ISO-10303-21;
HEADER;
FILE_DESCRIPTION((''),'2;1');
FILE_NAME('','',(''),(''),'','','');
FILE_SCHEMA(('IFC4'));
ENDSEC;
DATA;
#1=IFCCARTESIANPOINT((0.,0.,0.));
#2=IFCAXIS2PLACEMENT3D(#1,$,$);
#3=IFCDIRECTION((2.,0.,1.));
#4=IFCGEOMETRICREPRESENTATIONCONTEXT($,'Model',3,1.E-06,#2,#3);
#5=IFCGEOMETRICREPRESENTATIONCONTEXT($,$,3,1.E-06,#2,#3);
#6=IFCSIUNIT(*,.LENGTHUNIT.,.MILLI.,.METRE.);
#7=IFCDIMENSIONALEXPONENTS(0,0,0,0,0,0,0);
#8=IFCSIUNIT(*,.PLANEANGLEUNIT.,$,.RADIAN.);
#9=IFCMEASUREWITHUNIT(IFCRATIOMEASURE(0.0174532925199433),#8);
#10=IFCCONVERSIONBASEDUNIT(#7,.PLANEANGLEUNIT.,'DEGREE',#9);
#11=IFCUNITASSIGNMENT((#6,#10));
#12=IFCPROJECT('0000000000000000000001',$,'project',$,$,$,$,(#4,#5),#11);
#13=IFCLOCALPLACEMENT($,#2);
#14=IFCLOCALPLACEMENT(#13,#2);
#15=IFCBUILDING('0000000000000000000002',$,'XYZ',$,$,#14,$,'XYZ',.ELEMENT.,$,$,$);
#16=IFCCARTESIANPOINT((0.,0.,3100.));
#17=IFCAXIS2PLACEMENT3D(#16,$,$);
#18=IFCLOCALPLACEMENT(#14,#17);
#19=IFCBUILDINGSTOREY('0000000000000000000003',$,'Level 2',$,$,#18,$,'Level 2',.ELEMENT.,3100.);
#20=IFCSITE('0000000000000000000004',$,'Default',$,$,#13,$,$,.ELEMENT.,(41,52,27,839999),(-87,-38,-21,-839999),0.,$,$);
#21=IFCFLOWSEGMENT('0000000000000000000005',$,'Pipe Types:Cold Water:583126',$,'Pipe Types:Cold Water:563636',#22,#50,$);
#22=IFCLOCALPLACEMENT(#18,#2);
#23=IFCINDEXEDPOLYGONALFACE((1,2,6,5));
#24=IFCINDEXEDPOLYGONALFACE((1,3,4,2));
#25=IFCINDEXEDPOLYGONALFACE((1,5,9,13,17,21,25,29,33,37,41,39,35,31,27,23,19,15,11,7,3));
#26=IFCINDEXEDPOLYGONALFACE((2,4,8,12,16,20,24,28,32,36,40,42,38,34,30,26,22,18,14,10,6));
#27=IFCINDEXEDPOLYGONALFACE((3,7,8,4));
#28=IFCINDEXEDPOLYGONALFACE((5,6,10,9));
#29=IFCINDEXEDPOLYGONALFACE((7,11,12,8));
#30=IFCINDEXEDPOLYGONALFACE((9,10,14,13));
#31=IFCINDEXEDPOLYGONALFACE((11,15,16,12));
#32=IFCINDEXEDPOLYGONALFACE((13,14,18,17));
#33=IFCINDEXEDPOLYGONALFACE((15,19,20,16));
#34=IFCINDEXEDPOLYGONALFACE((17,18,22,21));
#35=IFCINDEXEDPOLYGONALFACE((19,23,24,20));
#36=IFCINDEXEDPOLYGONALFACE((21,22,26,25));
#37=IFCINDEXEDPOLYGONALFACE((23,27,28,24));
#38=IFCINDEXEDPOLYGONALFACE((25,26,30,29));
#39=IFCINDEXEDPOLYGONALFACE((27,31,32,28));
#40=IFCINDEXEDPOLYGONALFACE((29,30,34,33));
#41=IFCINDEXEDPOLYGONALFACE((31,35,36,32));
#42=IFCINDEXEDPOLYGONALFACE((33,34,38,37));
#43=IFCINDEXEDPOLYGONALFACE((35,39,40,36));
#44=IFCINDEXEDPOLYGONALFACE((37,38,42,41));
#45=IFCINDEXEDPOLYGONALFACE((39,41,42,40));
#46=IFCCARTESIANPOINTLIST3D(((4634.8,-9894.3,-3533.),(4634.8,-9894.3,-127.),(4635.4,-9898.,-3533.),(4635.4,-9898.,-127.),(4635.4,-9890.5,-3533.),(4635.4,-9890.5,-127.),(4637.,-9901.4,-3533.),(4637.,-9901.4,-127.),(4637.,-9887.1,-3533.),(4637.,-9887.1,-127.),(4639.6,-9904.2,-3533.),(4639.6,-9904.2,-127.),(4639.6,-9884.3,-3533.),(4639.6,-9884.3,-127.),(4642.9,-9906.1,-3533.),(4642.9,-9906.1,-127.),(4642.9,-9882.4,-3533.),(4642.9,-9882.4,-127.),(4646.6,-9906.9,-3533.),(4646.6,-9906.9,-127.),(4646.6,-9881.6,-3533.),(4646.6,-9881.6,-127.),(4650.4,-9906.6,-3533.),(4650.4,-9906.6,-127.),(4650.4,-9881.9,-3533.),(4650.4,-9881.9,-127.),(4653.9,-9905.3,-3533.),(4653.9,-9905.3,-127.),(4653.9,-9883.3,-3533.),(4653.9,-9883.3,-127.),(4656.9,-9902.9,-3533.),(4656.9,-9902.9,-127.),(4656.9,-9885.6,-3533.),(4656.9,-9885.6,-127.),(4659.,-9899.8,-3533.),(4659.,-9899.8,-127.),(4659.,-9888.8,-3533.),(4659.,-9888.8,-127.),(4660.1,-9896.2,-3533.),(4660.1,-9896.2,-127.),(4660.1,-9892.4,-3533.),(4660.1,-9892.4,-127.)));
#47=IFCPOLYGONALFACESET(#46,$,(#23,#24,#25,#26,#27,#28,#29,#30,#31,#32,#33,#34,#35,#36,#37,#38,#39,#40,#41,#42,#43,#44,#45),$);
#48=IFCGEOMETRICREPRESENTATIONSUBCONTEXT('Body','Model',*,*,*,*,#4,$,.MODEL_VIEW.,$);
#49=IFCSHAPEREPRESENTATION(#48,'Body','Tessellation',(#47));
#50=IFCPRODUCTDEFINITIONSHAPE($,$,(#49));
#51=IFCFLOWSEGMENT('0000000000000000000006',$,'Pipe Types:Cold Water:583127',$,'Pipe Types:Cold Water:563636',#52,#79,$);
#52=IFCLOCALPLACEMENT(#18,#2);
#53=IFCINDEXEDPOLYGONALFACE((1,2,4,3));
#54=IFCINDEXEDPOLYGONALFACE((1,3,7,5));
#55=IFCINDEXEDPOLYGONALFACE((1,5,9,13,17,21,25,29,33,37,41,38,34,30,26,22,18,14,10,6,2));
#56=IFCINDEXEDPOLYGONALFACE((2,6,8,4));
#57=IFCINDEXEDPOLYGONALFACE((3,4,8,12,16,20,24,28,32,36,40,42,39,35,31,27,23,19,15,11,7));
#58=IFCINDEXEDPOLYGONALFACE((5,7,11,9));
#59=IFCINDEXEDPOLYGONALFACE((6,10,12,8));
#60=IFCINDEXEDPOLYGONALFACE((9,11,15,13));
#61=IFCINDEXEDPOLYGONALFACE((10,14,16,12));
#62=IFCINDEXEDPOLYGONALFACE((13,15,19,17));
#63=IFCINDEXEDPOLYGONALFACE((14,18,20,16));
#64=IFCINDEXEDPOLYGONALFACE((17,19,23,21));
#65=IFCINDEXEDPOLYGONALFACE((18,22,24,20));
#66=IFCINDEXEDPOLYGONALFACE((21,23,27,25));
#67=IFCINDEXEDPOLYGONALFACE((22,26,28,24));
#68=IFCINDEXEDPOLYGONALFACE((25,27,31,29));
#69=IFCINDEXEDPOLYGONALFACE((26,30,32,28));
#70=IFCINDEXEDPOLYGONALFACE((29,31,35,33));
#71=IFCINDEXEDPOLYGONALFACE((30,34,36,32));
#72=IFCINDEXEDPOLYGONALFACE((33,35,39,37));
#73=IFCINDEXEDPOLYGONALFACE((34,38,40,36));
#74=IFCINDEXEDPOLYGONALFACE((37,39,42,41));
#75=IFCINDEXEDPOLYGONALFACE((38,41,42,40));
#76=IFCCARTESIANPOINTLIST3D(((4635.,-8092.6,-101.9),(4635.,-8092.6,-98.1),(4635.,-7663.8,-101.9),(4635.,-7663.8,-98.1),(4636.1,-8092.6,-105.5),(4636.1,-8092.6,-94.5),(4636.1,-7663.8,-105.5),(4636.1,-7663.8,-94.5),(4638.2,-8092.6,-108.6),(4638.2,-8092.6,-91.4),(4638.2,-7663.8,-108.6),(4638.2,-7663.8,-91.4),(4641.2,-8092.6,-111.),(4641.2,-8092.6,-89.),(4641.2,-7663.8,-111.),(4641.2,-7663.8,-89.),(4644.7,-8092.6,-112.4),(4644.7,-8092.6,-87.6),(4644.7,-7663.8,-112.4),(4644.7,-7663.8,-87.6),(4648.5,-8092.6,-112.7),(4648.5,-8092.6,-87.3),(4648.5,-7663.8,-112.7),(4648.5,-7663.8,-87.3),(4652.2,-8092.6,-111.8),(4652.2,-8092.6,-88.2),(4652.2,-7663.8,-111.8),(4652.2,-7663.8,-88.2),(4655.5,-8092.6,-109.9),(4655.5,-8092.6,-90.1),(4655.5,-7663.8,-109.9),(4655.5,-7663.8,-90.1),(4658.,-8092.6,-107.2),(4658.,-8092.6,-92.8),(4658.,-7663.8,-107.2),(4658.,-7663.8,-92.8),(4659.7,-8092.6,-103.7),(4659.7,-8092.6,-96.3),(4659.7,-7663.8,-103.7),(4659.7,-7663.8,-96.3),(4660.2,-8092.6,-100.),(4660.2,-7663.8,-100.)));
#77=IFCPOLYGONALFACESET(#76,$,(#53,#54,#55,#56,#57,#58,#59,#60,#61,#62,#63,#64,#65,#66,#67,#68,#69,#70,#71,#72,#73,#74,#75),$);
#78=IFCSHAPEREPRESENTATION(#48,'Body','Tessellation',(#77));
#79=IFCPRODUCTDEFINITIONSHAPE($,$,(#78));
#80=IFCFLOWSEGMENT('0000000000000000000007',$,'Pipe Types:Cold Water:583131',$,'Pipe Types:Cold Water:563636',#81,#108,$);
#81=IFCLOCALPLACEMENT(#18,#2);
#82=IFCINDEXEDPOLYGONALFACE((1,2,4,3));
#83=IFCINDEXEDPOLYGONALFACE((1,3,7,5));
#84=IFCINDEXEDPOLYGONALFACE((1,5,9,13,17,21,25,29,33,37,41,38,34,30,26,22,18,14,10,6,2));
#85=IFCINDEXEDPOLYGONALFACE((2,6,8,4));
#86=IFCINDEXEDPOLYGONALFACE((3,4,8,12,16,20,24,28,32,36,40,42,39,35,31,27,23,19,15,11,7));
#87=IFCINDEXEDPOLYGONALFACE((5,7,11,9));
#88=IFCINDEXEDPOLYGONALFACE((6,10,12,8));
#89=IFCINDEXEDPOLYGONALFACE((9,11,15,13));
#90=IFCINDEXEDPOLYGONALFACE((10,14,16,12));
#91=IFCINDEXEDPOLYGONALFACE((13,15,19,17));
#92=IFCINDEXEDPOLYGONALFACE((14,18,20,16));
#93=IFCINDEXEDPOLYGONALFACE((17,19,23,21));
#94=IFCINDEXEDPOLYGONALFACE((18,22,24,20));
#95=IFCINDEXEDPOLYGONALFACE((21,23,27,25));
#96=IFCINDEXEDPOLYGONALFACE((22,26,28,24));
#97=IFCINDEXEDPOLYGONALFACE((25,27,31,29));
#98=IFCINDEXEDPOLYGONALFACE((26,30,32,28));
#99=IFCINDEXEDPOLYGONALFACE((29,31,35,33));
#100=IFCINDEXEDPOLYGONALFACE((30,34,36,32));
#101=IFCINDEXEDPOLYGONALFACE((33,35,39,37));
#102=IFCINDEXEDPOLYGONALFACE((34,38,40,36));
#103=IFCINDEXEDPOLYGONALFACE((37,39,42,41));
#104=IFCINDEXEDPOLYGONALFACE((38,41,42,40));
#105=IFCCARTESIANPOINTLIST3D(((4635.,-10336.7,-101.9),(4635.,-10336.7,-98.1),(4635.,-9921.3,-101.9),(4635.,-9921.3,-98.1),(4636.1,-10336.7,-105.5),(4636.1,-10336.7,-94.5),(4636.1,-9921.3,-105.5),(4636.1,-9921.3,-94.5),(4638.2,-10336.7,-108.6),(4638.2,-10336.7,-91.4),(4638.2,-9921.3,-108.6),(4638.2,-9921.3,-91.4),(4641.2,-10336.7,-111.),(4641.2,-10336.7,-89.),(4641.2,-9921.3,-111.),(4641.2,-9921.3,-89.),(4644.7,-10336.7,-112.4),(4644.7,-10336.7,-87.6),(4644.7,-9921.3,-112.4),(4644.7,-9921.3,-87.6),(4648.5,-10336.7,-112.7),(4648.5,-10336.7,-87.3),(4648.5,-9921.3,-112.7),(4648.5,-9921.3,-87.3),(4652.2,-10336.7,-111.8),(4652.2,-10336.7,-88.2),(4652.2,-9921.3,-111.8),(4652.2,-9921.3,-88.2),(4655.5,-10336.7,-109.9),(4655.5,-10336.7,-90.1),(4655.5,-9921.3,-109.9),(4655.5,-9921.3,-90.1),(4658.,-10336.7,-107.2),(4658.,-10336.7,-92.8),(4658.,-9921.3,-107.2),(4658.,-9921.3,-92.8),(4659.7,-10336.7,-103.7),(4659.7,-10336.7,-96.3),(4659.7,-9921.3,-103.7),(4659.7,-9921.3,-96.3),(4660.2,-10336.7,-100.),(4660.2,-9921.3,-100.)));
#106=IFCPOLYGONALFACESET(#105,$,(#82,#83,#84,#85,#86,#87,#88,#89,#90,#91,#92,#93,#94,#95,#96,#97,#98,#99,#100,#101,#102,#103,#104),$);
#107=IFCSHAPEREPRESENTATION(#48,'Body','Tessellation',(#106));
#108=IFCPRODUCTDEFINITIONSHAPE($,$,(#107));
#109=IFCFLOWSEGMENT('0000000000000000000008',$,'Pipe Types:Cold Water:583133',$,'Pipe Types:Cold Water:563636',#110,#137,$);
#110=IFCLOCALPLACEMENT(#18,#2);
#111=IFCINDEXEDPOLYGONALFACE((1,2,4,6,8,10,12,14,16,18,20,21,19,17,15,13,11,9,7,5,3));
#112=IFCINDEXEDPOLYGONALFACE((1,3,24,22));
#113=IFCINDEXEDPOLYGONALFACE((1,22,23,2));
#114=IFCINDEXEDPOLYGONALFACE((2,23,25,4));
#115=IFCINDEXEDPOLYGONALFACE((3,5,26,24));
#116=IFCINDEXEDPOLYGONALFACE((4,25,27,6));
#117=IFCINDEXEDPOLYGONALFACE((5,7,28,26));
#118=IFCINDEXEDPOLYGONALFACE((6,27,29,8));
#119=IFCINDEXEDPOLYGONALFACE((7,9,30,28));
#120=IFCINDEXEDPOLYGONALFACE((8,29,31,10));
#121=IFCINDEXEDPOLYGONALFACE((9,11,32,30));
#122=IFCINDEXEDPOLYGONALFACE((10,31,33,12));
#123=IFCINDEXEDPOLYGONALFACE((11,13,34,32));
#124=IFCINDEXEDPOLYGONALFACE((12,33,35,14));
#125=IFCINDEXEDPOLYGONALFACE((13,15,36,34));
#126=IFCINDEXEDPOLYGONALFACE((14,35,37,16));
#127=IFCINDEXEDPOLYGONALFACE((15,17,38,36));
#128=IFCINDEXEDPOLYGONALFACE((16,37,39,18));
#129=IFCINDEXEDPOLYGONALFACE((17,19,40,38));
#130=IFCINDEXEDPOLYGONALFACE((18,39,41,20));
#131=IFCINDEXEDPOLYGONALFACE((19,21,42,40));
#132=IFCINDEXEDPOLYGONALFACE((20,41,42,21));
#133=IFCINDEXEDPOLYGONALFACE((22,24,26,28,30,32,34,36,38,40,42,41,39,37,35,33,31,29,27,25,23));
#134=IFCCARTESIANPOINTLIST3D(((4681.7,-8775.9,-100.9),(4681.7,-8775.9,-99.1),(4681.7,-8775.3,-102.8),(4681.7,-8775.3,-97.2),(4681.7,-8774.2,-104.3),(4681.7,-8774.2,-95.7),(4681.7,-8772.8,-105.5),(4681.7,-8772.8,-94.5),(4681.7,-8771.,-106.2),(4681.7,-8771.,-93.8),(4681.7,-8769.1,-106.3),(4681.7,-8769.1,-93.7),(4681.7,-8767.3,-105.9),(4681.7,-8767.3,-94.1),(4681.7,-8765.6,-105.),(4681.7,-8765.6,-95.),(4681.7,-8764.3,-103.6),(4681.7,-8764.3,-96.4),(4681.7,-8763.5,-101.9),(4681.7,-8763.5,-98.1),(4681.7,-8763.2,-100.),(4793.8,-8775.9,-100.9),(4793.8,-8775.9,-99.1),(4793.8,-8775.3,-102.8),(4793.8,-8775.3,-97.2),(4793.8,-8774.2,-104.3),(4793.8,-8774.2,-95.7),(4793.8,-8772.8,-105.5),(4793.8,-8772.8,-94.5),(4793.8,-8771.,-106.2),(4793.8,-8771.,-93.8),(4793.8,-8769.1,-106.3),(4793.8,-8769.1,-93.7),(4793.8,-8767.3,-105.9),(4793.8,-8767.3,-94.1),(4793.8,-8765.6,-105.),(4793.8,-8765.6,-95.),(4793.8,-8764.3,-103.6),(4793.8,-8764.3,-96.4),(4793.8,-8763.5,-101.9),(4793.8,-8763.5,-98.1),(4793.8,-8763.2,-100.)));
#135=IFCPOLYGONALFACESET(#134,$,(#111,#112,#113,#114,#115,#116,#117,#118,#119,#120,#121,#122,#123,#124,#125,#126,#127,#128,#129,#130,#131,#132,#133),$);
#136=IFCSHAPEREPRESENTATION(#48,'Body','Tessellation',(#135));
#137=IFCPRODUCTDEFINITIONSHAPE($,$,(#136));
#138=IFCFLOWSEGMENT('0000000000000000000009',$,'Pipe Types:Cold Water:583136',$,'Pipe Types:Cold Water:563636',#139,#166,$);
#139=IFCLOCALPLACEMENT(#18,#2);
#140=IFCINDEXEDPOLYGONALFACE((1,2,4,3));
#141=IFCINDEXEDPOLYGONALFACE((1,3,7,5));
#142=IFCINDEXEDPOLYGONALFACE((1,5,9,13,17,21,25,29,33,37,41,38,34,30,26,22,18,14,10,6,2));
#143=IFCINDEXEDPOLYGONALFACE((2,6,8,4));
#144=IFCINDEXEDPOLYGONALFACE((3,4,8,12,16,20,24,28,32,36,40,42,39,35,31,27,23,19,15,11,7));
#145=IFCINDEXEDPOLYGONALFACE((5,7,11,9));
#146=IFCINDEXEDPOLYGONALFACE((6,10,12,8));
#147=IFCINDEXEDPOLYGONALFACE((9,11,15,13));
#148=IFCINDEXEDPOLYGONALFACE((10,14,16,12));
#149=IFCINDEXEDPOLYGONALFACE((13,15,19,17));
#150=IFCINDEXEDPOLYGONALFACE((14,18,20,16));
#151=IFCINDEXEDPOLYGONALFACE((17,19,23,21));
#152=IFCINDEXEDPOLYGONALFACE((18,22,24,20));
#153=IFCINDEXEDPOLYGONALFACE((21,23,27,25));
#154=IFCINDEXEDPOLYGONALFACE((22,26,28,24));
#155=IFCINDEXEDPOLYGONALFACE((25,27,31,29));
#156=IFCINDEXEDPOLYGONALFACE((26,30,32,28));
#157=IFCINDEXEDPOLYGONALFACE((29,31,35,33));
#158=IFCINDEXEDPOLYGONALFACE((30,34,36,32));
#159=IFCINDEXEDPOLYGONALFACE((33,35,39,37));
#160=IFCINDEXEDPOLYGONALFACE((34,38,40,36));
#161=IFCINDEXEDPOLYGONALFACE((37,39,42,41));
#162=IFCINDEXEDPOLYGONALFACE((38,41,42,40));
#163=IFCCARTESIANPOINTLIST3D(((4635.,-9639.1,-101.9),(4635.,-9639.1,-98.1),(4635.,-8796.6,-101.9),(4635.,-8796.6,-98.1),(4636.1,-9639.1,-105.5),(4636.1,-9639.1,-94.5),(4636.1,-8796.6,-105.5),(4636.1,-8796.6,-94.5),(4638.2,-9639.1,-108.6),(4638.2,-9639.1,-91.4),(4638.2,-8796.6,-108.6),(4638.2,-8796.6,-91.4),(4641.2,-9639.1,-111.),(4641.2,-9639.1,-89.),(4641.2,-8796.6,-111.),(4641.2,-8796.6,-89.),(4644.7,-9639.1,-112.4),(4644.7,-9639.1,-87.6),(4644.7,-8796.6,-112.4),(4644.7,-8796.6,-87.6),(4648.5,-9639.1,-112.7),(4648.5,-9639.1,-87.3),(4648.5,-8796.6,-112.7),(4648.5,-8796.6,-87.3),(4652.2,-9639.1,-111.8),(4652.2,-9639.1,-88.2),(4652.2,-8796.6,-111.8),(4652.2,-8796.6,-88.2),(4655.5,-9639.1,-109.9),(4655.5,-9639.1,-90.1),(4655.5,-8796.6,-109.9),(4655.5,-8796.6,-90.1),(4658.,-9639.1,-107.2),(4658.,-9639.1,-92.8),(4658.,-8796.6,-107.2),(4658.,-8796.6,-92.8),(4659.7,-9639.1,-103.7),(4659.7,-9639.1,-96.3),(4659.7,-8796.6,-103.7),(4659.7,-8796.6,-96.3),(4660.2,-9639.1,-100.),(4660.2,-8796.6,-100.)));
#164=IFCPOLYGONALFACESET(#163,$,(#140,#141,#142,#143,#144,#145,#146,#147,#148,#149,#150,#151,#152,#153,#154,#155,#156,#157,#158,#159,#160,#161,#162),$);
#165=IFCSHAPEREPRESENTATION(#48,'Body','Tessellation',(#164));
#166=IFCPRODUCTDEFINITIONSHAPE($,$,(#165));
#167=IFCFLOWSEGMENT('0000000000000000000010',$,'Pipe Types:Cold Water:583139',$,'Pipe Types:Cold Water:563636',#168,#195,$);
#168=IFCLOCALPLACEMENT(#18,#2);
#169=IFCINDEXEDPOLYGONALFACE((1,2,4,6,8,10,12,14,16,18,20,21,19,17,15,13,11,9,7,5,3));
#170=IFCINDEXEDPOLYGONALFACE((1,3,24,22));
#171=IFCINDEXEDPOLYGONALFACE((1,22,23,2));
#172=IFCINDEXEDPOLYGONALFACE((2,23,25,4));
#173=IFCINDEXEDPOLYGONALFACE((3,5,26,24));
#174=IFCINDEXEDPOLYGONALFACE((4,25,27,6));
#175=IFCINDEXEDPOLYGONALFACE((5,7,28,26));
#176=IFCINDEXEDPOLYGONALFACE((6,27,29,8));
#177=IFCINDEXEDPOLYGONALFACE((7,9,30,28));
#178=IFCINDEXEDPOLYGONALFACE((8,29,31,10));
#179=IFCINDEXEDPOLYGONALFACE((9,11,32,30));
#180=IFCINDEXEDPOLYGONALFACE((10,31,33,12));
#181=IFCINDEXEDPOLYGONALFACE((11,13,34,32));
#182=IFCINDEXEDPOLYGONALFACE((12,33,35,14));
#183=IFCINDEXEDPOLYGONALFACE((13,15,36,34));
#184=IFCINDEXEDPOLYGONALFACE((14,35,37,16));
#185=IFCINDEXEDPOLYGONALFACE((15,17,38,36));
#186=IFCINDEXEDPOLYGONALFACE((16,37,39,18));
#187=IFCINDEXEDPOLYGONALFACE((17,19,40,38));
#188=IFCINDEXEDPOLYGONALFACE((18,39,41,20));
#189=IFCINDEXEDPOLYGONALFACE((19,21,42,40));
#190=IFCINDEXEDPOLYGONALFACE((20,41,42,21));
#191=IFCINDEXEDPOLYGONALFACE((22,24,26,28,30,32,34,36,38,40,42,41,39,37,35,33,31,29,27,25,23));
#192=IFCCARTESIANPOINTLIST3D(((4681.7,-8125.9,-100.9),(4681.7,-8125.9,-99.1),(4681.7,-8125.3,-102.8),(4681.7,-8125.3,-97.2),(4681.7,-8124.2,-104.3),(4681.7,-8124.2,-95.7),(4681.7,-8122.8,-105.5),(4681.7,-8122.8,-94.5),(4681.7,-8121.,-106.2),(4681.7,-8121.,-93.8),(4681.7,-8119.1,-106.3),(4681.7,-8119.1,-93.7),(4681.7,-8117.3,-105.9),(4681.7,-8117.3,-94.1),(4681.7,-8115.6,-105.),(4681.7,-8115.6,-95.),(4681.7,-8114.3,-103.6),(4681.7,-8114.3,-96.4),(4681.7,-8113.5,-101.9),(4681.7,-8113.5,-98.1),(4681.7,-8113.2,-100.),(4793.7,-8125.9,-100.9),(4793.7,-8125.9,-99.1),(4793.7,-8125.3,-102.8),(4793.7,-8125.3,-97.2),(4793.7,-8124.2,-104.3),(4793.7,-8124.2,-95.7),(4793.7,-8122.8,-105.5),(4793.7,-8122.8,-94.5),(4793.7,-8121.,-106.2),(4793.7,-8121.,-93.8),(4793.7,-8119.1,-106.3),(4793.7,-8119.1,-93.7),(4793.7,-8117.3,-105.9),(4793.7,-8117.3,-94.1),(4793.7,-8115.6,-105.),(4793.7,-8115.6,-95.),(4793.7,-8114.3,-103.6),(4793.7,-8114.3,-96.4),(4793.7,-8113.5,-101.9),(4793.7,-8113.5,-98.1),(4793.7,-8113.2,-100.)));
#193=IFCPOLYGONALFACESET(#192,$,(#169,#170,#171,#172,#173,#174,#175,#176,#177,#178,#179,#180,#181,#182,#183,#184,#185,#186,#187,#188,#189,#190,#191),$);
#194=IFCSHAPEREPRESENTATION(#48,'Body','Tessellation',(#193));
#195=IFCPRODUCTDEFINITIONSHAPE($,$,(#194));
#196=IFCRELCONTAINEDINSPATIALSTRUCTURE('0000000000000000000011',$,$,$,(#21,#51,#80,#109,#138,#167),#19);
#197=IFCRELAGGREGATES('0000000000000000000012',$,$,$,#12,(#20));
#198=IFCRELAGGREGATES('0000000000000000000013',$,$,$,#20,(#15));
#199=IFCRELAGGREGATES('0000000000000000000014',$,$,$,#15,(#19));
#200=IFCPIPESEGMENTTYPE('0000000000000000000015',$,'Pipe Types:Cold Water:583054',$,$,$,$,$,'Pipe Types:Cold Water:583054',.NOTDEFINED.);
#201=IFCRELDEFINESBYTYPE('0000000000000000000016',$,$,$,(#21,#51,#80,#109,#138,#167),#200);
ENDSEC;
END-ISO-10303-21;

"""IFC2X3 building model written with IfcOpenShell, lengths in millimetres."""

from ifc_helpers import new_model, entity, si_unit, converted_unit, direction, frame, frame_2d, origin, origin_2d_with_axis, place, context, subcontext, project, spatial, circle, extrude, type_object, element, save


model = new_model("IFC2X3")

# Units and contexts
model_context = context("Model", 3, precision=1e-06, world=origin(), true_north=direction((2.0, 0.0, 1.0)))
context_of_model = context(None, 3, precision=1e-06, world=origin(), true_north=direction((2.0, 0.0, 1.0)))
body_context = subcontext(model_context, "Body", "Model", "MODEL_VIEW")
ifc_project = project(units=[si_unit("LENGTHUNIT", "METRE", prefix="MILLI"), converted_unit("PLANEANGLEUNIT", "DEGREE", entity("IfcRatioMeasure", 0.0174532925199433), si_unit("PLANEANGLEUNIT", "RADIAN"), dimensions=[0, 0, 0, 0, 0, 0, 0])], contexts=[model_context, context_of_model])

# Site, building, storey
site_placement = place(None, origin())
site = spatial("IfcSite", under=ifc_project, at=site_placement, Name="Default", CompositionType="ELEMENT", RefLatitude=(41, 52, 27, 839999), RefLongitude=(-87, -38, -21, -839999), RefElevation=0.0)
building_placement = place(site_placement, origin())
building = spatial("IfcBuilding", under=site, at=building_placement, Name="XYZ", LongName="XYZ", CompositionType="ELEMENT")
storey_placement = place(building_placement, frame((0.0, 0.0, 3100.0)))
storey = spatial("IfcBuildingStorey", under=building, at=storey_placement, Name="Level 2", LongName="Level 2", CompositionType="ELEMENT", Elevation=3100.0)

# Flow segments
pipe_segment_type_1 = type_object("IfcPipeSegmentType", Name="Pipe Types:Cold Water:583054", ElementType="Pipe Types:Cold Water:583054", PredefinedType="NOTDEFINED")
flow_segment_1_placement = place(storey_placement, origin())
element("IfcFlowSegment", 1, at=flow_segment_1_placement, inside=storey, type_object=pipe_segment_type_1, Name="Pipe Types:Cold Water:583126", ObjectType="Pipe Types:Cold Water:563636", context=body_context, shape_type="SweptSolid", body=[
    extrude(circle(Radius=12.7, at=origin_2d_with_axis()), frame((4647.5, -9894.3, -3533.0), z_axis=(0.0, 0.0, 1.0), x_axis=(-1.0, 0.0, 0.0)), (0.0, 0.0, 1.0), 3406.0),
])
flow_segment_2_placement = place(storey_placement, origin())
element("IfcFlowSegment", 2, at=flow_segment_2_placement, inside=storey, type_object=pipe_segment_type_1, Name="Pipe Types:Cold Water:583127", ObjectType="Pipe Types:Cold Water:563636", context=body_context, shape_type="SweptSolid", body=[
    extrude(circle(Radius=12.7, at=frame_2d((0.0, 0.0), x_axis=(1.0, 0.0))), frame((4647.5, -8092.6, -100.0), z_axis=(0.0, 1.0, 0.0), x_axis=(1.0, 0.0, 0.0)), (0.0, 0.0, 1.0), 428.7),
])
flow_segment_3_placement = place(storey_placement, origin())
element("IfcFlowSegment", 3, at=flow_segment_3_placement, inside=storey, type_object=pipe_segment_type_1, Name="Pipe Types:Cold Water:583131", ObjectType="Pipe Types:Cold Water:563636", context=body_context, shape_type="SweptSolid", body=[
    extrude(circle(Radius=12.7, at=origin_2d_with_axis()), frame((4647.5, -10336.7, -100.0), z_axis=(0.0, 1.0, 0.0), x_axis=(1.0, 0.0, 0.0)), (0.0, 0.0, 1.0), 415.5),
])
flow_segment_4_placement = place(storey_placement, origin())
element("IfcFlowSegment", 4, at=flow_segment_4_placement, inside=storey, type_object=pipe_segment_type_1, Name="Pipe Types:Cold Water:583133", ObjectType="Pipe Types:Cold Water:563636", context=body_context, shape_type="SweptSolid", body=[
    extrude(circle(Radius=6.3, at=origin_2d_with_axis()), frame((4681.7, -8769.6, -100.0), z_axis=(1.0, 0.0, 0.0), x_axis=(0.0, 1.0, 0.0)), (0.0, 0.0, 1.0), 112.1),
])
flow_segment_5_placement = place(storey_placement, origin())
element("IfcFlowSegment", 5, at=flow_segment_5_placement, inside=storey, type_object=pipe_segment_type_1, Name="Pipe Types:Cold Water:583136", ObjectType="Pipe Types:Cold Water:563636", context=body_context, shape_type="SweptSolid", body=[
    extrude(circle(Radius=12.7, at=origin_2d_with_axis()), frame((4647.5, -9639.1, -100.0), z_axis=(0.0, 1.0, 0.0), x_axis=(1.0, 0.0, 0.0)), (0.0, 0.0, 1.0), 842.5),
])
flow_segment_6_placement = place(storey_placement, origin())
element("IfcFlowSegment", 6, at=flow_segment_6_placement, inside=storey, type_object=pipe_segment_type_1, Name="Pipe Types:Cold Water:583139", ObjectType="Pipe Types:Cold Water:563636", context=body_context, shape_type="SweptSolid", body=[
    extrude(circle(Radius=6.3, at=frame_2d((0.0, 0.0), x_axis=(1.0, 0.0))), frame((4681.7, -8119.6, -100.0), z_axis=(1.0, 0.0, 0.0), x_axis=(0.0, 1.0, 0.0)), (0.0, 0.0, 1.0), 112.1),
])

save(model, "model.ifc")
